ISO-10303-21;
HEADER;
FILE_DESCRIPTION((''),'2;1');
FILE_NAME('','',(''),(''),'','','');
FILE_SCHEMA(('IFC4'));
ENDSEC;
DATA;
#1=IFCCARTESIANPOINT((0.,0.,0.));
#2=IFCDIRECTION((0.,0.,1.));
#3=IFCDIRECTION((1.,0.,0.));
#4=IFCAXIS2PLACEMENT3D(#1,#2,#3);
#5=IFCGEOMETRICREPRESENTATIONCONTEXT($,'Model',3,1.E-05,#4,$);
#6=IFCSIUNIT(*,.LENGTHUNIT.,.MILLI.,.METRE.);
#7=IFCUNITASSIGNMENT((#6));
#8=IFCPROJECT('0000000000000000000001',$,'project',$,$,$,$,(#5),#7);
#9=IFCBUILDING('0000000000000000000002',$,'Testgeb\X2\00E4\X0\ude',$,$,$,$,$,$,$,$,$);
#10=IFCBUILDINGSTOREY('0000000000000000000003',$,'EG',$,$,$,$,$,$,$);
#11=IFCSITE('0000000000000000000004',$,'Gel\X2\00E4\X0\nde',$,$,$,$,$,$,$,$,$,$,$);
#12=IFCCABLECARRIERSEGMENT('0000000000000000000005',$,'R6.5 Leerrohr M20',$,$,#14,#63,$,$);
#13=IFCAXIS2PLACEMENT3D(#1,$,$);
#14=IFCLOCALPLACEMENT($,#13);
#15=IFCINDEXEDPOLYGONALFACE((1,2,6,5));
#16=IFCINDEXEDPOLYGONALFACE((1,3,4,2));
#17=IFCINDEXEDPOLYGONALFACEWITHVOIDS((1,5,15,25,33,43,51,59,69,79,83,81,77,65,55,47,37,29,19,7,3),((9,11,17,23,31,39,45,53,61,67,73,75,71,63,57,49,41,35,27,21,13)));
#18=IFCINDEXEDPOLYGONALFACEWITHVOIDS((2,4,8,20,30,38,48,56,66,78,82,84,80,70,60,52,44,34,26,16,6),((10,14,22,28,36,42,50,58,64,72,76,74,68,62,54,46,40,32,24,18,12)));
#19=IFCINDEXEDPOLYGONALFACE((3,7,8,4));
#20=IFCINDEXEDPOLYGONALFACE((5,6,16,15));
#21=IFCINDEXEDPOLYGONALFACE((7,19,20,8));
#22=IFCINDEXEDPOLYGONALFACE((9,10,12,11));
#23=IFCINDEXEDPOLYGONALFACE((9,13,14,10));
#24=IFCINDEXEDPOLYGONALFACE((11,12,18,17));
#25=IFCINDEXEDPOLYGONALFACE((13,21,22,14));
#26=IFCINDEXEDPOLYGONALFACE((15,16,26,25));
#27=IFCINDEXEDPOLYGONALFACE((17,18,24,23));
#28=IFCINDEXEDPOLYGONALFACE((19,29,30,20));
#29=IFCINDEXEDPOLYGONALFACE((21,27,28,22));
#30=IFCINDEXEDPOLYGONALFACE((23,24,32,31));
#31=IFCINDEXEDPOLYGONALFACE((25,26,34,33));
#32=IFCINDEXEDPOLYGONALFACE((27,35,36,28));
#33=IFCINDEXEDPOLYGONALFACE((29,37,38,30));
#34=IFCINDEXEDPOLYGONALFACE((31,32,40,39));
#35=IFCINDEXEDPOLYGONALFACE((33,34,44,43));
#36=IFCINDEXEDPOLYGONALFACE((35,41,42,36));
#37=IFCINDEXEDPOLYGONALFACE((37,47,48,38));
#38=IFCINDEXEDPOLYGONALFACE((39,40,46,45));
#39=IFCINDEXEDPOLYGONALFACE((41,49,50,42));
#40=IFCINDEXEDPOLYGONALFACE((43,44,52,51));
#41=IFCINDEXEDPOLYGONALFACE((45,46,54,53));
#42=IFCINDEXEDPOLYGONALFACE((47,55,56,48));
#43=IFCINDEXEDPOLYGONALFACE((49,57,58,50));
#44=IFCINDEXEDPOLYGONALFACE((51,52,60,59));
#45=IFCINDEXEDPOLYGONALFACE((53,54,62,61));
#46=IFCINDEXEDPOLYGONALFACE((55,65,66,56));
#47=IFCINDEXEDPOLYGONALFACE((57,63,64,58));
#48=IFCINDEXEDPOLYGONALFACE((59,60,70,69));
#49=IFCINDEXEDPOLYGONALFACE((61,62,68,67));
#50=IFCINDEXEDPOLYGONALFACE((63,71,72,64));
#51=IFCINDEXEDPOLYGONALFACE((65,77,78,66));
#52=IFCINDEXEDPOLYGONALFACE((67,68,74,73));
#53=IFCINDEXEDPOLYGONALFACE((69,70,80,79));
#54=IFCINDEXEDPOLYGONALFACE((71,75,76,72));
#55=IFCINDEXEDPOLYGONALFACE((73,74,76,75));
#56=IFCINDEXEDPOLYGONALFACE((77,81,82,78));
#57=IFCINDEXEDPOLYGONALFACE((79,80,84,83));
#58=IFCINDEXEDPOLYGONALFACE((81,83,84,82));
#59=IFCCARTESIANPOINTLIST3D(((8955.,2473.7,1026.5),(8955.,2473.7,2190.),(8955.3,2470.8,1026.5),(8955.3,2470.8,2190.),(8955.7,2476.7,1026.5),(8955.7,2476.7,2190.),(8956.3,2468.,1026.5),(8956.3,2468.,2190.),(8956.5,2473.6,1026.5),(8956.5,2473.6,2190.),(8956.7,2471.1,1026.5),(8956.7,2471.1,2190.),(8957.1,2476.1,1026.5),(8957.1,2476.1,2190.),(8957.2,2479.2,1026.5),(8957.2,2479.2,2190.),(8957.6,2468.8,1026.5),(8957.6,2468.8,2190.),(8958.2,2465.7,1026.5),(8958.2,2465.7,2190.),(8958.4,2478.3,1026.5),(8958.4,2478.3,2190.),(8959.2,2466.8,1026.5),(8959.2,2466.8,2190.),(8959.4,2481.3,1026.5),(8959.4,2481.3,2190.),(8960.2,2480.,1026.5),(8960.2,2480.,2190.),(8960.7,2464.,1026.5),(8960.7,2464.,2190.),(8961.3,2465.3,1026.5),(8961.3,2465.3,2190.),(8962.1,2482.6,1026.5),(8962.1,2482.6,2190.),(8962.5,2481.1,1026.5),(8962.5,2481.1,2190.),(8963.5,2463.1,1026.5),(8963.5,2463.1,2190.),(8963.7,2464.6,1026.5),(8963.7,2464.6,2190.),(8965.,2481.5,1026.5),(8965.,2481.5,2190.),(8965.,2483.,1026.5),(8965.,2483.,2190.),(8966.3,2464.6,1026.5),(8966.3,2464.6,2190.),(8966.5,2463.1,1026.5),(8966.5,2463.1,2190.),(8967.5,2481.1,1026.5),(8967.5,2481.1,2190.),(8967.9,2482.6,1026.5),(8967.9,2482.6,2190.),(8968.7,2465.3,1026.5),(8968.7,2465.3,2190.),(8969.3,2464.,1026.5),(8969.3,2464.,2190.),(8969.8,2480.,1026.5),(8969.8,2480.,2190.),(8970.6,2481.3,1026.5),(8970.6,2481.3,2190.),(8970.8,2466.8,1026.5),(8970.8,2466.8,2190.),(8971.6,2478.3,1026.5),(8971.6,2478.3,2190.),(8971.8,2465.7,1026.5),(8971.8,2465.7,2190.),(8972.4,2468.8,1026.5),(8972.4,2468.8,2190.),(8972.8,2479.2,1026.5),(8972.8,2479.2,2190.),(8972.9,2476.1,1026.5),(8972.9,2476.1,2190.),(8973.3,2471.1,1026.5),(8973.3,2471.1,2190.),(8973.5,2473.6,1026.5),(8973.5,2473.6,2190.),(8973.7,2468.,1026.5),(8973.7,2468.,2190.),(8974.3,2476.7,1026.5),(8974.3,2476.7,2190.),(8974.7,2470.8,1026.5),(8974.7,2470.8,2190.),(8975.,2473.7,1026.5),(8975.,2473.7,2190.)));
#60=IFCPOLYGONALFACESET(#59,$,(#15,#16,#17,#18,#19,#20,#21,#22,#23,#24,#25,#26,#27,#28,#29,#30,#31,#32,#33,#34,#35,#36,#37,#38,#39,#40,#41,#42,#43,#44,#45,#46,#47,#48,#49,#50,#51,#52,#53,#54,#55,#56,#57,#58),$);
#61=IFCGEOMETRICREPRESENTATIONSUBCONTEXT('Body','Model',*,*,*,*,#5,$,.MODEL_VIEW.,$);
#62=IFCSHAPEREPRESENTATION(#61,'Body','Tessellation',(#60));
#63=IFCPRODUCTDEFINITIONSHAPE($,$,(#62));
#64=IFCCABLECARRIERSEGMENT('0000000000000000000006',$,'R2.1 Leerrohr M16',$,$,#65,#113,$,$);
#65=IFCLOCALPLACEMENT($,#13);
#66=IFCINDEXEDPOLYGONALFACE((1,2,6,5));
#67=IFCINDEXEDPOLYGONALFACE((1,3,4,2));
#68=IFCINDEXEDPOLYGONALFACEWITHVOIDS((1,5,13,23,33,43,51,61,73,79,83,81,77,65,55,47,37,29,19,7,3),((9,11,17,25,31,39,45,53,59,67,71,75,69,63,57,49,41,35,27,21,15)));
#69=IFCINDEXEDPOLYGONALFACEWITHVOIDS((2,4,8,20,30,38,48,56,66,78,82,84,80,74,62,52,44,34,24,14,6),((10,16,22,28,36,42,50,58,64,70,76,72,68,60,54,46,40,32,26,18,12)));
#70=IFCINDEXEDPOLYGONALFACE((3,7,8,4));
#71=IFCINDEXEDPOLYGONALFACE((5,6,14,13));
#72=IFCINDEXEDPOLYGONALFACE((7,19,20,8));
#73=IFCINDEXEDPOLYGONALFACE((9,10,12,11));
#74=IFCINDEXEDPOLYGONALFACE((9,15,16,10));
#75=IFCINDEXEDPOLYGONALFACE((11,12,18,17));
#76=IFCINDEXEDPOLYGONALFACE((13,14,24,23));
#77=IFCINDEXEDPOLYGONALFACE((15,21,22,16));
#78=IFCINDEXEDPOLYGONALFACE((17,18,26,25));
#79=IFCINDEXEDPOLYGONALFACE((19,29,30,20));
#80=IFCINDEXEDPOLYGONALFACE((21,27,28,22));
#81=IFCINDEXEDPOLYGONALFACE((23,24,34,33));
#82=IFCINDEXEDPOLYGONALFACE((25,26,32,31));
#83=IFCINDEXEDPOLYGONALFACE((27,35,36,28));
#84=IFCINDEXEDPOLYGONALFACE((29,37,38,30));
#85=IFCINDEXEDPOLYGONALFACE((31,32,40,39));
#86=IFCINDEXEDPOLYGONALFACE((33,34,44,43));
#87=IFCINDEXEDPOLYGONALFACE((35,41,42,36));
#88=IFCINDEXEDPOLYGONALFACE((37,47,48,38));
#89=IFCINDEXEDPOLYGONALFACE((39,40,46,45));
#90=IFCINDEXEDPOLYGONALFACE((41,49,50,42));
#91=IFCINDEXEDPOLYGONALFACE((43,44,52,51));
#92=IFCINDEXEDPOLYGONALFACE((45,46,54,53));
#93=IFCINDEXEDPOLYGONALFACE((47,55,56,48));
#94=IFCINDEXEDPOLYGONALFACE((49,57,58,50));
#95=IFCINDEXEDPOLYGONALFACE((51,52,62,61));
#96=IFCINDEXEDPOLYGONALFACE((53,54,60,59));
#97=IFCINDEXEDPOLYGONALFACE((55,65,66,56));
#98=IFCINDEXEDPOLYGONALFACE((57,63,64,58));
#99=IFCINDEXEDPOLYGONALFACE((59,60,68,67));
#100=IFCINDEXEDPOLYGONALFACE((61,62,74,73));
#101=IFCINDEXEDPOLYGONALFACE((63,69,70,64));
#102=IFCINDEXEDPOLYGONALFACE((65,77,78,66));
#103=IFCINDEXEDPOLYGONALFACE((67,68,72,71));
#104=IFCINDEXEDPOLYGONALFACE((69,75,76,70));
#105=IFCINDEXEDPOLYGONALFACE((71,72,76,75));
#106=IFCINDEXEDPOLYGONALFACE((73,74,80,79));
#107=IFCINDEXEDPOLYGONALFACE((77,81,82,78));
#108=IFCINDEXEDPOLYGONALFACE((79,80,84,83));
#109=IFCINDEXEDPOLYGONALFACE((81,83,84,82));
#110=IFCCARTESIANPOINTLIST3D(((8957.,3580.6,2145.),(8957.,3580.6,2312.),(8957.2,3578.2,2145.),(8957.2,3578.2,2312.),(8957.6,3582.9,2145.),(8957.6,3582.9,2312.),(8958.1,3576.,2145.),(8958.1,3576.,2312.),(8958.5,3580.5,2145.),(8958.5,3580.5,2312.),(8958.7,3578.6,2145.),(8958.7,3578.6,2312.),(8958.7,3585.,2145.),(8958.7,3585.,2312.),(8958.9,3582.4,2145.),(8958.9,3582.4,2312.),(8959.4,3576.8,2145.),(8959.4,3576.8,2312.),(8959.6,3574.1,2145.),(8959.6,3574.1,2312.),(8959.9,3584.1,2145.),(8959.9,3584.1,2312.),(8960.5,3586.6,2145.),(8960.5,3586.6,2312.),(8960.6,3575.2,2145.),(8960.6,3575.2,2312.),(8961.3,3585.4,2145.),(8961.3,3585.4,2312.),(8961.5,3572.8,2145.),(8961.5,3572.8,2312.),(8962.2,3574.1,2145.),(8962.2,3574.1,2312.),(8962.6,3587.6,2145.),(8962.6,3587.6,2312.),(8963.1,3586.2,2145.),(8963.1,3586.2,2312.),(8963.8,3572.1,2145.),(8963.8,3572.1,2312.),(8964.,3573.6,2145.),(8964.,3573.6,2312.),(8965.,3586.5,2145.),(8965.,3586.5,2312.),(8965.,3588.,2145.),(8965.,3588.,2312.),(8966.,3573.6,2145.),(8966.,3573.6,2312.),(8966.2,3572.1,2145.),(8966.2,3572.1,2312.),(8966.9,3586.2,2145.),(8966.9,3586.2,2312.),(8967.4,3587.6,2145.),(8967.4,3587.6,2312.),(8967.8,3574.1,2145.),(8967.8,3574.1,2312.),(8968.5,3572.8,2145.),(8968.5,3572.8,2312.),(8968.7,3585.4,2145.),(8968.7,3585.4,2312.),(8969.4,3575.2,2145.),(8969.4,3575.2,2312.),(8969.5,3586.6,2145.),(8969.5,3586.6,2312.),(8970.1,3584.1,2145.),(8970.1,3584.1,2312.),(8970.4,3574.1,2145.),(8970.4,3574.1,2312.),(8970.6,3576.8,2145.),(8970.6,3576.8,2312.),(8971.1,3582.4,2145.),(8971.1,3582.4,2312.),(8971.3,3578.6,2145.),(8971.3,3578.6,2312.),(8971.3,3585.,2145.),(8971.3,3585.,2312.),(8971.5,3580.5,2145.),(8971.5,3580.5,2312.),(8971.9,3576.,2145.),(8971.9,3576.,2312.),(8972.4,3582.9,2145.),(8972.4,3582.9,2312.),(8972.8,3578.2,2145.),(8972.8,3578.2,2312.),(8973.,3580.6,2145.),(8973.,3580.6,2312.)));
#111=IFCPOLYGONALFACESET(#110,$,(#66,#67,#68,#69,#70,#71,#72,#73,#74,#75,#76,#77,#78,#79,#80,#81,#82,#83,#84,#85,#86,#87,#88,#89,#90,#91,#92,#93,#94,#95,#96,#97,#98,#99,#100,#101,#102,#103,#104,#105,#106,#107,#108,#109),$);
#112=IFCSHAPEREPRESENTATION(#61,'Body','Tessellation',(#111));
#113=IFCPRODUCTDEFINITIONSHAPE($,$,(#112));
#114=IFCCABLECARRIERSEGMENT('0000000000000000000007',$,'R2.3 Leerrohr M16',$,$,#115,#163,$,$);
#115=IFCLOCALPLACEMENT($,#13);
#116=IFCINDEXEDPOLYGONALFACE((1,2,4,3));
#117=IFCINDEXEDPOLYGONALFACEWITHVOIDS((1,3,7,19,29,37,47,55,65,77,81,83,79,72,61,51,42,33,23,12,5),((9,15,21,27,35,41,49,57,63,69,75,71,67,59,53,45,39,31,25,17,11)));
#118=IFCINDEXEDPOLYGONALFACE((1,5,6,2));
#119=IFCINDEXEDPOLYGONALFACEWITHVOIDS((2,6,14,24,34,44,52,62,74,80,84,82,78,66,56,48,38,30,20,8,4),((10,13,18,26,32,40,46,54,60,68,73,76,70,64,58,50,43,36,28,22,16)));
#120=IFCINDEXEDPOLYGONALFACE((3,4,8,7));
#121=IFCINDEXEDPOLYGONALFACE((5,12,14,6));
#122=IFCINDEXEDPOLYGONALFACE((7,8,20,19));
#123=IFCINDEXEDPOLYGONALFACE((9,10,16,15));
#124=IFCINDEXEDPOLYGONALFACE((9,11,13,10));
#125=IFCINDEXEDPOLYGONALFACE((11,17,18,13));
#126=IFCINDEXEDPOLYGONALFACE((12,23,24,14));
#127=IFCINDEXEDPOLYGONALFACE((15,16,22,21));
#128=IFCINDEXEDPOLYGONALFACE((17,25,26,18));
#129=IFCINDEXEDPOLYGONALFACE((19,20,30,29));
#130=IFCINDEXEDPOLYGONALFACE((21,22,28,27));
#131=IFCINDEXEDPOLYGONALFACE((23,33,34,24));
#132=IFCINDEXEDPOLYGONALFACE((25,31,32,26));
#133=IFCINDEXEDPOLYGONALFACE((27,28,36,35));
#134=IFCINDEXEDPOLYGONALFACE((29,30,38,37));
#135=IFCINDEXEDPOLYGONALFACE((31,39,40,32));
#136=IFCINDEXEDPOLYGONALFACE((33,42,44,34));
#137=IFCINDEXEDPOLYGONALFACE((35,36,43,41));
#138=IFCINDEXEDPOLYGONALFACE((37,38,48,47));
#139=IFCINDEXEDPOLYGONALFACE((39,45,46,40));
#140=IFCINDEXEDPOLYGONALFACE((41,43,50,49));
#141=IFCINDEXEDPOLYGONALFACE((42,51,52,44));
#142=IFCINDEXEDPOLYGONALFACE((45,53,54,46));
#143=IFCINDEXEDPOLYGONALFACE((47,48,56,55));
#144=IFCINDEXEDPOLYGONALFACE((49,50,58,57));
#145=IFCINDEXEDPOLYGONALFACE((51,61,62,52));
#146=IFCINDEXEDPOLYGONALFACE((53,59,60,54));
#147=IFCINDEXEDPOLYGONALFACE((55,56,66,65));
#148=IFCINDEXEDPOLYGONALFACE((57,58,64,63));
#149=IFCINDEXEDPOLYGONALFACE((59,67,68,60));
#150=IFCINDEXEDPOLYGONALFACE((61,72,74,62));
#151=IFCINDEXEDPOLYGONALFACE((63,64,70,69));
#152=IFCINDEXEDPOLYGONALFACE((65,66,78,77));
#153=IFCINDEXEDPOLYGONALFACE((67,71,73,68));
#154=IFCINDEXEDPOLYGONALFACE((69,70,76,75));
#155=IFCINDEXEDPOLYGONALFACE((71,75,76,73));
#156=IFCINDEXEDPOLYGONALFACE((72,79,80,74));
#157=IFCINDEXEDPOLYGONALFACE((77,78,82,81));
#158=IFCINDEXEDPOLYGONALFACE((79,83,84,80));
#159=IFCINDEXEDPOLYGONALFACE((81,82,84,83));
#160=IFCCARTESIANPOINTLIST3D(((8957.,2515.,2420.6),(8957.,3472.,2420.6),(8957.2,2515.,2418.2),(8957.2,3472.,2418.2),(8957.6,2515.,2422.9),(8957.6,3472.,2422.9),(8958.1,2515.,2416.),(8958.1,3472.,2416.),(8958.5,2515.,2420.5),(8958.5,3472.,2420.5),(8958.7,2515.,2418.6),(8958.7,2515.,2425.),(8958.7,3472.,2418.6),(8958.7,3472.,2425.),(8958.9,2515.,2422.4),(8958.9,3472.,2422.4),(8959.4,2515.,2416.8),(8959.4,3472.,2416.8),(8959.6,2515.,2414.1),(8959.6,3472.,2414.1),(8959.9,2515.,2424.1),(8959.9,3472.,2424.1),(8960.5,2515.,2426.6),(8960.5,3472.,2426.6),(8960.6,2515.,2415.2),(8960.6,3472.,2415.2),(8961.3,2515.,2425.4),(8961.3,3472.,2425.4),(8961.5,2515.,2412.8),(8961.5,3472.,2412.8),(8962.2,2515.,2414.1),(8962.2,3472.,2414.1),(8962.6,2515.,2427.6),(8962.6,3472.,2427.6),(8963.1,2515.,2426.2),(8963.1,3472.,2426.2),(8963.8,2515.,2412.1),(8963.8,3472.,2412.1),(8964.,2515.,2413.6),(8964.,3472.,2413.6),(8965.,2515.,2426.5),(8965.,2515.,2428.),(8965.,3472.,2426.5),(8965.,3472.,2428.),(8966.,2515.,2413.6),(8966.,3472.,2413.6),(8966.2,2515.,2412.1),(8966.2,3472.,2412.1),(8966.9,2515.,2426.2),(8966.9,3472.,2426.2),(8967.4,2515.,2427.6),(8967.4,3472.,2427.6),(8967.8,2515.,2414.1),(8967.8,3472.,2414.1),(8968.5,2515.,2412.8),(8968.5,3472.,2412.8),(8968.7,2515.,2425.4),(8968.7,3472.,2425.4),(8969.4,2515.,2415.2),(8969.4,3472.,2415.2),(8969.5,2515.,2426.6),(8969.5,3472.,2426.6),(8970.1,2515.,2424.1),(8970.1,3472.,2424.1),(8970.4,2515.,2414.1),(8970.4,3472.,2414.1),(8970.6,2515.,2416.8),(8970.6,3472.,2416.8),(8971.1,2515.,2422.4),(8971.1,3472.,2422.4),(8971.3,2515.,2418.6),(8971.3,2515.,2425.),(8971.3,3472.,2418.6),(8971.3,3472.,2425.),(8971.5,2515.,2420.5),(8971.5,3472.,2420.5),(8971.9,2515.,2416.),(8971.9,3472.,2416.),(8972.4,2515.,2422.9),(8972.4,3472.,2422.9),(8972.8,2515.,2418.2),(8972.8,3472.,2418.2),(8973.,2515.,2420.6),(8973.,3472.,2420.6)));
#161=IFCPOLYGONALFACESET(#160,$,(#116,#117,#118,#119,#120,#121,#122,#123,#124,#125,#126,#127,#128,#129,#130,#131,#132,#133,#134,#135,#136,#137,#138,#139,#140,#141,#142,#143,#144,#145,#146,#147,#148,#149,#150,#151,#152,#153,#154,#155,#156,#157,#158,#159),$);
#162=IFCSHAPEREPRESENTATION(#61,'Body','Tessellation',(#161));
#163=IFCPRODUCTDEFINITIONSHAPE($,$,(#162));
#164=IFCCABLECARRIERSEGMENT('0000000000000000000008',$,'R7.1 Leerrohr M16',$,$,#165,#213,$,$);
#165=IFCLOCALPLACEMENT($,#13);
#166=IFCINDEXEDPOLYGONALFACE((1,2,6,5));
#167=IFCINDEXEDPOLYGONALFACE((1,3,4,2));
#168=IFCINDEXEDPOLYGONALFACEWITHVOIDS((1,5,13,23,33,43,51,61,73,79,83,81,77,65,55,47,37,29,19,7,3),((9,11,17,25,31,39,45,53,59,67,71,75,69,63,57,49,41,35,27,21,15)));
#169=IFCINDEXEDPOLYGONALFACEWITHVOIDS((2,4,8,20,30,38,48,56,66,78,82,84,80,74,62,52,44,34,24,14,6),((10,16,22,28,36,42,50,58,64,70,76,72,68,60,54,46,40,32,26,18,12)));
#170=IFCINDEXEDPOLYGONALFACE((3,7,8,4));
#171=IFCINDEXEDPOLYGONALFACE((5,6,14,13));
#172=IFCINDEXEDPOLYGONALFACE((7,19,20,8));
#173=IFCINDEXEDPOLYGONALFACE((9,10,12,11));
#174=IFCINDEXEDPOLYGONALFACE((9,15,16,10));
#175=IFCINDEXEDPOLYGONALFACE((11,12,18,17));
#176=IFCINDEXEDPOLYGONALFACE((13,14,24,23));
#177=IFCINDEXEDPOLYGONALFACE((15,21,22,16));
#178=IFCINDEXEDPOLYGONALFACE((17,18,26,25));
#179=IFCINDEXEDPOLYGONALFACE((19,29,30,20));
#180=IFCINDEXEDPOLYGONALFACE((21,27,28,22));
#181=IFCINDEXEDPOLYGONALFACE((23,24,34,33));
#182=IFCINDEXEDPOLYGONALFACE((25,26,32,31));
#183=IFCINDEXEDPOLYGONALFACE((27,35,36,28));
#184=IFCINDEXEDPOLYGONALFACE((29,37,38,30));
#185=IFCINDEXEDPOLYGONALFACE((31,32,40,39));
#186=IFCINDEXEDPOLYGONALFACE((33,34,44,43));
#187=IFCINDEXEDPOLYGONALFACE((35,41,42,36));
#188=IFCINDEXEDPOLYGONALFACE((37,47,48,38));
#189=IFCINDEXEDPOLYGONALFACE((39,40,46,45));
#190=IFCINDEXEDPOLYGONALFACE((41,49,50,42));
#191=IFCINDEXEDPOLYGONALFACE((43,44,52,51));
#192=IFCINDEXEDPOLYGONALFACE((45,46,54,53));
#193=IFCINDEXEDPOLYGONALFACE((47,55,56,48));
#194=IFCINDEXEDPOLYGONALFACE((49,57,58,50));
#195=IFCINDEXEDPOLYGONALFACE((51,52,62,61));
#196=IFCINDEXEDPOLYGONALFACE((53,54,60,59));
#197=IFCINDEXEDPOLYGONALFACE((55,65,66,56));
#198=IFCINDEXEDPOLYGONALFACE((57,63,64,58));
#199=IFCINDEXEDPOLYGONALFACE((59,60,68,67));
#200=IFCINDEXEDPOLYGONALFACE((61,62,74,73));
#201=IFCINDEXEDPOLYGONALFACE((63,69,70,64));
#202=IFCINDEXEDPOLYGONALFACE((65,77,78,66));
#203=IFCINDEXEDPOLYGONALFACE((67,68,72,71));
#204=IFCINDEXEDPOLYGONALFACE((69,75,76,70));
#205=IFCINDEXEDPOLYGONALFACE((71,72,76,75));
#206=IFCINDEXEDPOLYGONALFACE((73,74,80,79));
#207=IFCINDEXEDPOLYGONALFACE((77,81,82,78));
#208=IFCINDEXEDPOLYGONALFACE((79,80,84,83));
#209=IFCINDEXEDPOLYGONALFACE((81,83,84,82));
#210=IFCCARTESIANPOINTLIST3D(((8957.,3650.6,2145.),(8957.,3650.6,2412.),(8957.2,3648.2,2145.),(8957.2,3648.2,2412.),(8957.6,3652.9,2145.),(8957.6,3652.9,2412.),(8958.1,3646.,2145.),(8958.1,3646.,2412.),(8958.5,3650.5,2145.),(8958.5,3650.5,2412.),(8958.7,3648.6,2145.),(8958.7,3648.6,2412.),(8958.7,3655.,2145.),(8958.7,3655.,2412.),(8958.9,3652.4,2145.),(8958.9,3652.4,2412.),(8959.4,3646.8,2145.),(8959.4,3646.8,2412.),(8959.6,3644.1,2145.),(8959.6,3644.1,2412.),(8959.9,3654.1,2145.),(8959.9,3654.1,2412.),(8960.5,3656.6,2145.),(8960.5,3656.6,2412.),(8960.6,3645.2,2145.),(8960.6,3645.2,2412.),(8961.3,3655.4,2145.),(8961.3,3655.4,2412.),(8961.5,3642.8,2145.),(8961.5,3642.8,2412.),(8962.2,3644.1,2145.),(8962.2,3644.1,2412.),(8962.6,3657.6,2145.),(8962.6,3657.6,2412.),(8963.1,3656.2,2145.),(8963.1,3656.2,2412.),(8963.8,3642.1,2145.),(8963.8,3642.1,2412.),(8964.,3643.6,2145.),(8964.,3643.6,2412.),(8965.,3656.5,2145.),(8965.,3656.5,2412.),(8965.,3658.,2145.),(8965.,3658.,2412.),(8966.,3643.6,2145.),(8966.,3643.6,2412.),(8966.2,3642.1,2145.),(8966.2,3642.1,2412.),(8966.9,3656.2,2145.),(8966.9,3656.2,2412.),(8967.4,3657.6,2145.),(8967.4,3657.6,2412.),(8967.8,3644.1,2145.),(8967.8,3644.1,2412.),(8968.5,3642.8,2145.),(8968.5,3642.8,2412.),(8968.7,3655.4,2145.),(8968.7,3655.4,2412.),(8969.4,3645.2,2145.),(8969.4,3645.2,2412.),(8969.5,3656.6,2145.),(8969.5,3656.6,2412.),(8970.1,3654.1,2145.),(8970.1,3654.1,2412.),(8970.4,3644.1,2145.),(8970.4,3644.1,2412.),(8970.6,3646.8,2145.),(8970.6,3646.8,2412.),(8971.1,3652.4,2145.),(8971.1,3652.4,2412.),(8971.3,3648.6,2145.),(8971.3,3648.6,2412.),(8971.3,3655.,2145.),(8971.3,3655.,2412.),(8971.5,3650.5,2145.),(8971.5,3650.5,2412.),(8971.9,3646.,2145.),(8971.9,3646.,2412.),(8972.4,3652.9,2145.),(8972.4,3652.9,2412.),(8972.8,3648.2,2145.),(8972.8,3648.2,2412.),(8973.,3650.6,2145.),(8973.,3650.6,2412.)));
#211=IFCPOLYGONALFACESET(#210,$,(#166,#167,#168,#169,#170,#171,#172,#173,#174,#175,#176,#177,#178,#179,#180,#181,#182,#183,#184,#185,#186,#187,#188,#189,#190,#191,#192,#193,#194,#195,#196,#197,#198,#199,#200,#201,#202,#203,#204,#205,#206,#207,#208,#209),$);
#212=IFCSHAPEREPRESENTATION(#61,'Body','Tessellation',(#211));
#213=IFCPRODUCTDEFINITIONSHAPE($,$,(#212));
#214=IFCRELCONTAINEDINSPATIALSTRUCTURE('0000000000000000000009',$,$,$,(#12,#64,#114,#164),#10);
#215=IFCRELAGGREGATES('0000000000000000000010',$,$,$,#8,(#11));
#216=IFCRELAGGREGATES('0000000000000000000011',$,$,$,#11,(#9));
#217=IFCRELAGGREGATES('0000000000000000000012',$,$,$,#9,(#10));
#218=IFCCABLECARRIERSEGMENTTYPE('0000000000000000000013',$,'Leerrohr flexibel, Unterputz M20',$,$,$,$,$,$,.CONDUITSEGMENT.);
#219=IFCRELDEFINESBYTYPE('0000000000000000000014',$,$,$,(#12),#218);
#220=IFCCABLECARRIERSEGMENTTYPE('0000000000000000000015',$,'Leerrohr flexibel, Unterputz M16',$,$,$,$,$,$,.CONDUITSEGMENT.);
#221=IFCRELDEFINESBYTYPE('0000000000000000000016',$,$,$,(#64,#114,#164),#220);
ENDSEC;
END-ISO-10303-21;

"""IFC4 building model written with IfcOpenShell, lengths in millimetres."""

from ifc_helpers import new_model, si_unit, frame, origin_with_axes, place, context, subcontext, project, spatial, hollow_circle, extrude, type_object, element, save


model = new_model("IFC4")

# Units and contexts
model_context = context("Model", 3, precision=1e-05, world=origin_with_axes())
body_context = subcontext(model_context, "Body", "Model", "MODEL_VIEW")
ifc_project = project(units=[si_unit("LENGTHUNIT", "METRE", prefix="MILLI")], contexts=[model_context])

# Site, building, storey
site = spatial("IfcSite", under=ifc_project, Name="Gelände")
building = spatial("IfcBuilding", under=site, Name="Testgebäude")
storey = spatial("IfcBuildingStorey", under=building, Name="EG")

# Cable carrier segment
cable_carrier_segment_type_1 = type_object("IfcCableCarrierSegmentType", Name="Leerrohr flexibel, Unterputz M20", PredefinedType="CONDUITSEGMENT")
cable_carrier_segment_1_placement = place(None, frame((8965.0, 2473.0, 2190.0), z_axis=(0.0, 0.0, -1.0), x_axis=(0.0, 1.0, 0.0)))
element("IfcCableCarrierSegment", 1, at=cable_carrier_segment_1_placement, inside=storey, type_object=cable_carrier_segment_type_1, Name="R6.5 Leerrohr M20", context=body_context, shape_type="SweptSolid", body=[
    extrude(hollow_circle(Radius=10.0, WallThickness=1.5), None, (0.0, 0.0, 1.0), 1163.5),
])

# Cable carrier segments
cable_carrier_segment_type_2 = type_object("IfcCableCarrierSegmentType", Name="Leerrohr flexibel, Unterputz M16", PredefinedType="CONDUITSEGMENT")
cable_carrier_segment_2_placement = place(None, frame((8965.0, 3580.0, 2145.0), z_axis=(0.0, 0.0, 1.0), x_axis=(0.0, 1.0, 0.0)))
element("IfcCableCarrierSegment", 2, at=cable_carrier_segment_2_placement, inside=storey, type_object=cable_carrier_segment_type_2, Name="R2.1 Leerrohr M16", context=body_context, shape_type="SweptSolid", body=[
    extrude(hollow_circle(Radius=8.0, WallThickness=1.5), None, (0.0, 0.0, 1.0), 167.0),
])
cable_carrier_segment_3_placement = place(None, frame((8965.0, 3472.0, 2420.0), z_axis=(0.0, -1.0, 0.0), x_axis=(0.0, 0.0, 1.0)))
element("IfcCableCarrierSegment", 3, at=cable_carrier_segment_3_placement, inside=storey, type_object=cable_carrier_segment_type_2, Name="R2.3 Leerrohr M16", context=body_context, shape_type="SweptSolid", body=[
    extrude(hollow_circle(Radius=8.0, WallThickness=1.5), None, (0.0, 0.0, 1.0), 957.0),
])
cable_carrier_segment_4_placement = place(None, frame((8965.0, 3650.0, 2145.0), z_axis=(0.0, 0.0, 1.0), x_axis=(0.0, 1.0, 0.0)))
element("IfcCableCarrierSegment", 4, at=cable_carrier_segment_4_placement, inside=storey, type_object=cable_carrier_segment_type_2, Name="R7.1 Leerrohr M16", context=body_context, shape_type="SweptSolid", body=[
    extrude(hollow_circle(Radius=8.0, WallThickness=1.5), None, (0.0, 0.0, 1.0), 267.0),
])

save(model, "model.ifc")
